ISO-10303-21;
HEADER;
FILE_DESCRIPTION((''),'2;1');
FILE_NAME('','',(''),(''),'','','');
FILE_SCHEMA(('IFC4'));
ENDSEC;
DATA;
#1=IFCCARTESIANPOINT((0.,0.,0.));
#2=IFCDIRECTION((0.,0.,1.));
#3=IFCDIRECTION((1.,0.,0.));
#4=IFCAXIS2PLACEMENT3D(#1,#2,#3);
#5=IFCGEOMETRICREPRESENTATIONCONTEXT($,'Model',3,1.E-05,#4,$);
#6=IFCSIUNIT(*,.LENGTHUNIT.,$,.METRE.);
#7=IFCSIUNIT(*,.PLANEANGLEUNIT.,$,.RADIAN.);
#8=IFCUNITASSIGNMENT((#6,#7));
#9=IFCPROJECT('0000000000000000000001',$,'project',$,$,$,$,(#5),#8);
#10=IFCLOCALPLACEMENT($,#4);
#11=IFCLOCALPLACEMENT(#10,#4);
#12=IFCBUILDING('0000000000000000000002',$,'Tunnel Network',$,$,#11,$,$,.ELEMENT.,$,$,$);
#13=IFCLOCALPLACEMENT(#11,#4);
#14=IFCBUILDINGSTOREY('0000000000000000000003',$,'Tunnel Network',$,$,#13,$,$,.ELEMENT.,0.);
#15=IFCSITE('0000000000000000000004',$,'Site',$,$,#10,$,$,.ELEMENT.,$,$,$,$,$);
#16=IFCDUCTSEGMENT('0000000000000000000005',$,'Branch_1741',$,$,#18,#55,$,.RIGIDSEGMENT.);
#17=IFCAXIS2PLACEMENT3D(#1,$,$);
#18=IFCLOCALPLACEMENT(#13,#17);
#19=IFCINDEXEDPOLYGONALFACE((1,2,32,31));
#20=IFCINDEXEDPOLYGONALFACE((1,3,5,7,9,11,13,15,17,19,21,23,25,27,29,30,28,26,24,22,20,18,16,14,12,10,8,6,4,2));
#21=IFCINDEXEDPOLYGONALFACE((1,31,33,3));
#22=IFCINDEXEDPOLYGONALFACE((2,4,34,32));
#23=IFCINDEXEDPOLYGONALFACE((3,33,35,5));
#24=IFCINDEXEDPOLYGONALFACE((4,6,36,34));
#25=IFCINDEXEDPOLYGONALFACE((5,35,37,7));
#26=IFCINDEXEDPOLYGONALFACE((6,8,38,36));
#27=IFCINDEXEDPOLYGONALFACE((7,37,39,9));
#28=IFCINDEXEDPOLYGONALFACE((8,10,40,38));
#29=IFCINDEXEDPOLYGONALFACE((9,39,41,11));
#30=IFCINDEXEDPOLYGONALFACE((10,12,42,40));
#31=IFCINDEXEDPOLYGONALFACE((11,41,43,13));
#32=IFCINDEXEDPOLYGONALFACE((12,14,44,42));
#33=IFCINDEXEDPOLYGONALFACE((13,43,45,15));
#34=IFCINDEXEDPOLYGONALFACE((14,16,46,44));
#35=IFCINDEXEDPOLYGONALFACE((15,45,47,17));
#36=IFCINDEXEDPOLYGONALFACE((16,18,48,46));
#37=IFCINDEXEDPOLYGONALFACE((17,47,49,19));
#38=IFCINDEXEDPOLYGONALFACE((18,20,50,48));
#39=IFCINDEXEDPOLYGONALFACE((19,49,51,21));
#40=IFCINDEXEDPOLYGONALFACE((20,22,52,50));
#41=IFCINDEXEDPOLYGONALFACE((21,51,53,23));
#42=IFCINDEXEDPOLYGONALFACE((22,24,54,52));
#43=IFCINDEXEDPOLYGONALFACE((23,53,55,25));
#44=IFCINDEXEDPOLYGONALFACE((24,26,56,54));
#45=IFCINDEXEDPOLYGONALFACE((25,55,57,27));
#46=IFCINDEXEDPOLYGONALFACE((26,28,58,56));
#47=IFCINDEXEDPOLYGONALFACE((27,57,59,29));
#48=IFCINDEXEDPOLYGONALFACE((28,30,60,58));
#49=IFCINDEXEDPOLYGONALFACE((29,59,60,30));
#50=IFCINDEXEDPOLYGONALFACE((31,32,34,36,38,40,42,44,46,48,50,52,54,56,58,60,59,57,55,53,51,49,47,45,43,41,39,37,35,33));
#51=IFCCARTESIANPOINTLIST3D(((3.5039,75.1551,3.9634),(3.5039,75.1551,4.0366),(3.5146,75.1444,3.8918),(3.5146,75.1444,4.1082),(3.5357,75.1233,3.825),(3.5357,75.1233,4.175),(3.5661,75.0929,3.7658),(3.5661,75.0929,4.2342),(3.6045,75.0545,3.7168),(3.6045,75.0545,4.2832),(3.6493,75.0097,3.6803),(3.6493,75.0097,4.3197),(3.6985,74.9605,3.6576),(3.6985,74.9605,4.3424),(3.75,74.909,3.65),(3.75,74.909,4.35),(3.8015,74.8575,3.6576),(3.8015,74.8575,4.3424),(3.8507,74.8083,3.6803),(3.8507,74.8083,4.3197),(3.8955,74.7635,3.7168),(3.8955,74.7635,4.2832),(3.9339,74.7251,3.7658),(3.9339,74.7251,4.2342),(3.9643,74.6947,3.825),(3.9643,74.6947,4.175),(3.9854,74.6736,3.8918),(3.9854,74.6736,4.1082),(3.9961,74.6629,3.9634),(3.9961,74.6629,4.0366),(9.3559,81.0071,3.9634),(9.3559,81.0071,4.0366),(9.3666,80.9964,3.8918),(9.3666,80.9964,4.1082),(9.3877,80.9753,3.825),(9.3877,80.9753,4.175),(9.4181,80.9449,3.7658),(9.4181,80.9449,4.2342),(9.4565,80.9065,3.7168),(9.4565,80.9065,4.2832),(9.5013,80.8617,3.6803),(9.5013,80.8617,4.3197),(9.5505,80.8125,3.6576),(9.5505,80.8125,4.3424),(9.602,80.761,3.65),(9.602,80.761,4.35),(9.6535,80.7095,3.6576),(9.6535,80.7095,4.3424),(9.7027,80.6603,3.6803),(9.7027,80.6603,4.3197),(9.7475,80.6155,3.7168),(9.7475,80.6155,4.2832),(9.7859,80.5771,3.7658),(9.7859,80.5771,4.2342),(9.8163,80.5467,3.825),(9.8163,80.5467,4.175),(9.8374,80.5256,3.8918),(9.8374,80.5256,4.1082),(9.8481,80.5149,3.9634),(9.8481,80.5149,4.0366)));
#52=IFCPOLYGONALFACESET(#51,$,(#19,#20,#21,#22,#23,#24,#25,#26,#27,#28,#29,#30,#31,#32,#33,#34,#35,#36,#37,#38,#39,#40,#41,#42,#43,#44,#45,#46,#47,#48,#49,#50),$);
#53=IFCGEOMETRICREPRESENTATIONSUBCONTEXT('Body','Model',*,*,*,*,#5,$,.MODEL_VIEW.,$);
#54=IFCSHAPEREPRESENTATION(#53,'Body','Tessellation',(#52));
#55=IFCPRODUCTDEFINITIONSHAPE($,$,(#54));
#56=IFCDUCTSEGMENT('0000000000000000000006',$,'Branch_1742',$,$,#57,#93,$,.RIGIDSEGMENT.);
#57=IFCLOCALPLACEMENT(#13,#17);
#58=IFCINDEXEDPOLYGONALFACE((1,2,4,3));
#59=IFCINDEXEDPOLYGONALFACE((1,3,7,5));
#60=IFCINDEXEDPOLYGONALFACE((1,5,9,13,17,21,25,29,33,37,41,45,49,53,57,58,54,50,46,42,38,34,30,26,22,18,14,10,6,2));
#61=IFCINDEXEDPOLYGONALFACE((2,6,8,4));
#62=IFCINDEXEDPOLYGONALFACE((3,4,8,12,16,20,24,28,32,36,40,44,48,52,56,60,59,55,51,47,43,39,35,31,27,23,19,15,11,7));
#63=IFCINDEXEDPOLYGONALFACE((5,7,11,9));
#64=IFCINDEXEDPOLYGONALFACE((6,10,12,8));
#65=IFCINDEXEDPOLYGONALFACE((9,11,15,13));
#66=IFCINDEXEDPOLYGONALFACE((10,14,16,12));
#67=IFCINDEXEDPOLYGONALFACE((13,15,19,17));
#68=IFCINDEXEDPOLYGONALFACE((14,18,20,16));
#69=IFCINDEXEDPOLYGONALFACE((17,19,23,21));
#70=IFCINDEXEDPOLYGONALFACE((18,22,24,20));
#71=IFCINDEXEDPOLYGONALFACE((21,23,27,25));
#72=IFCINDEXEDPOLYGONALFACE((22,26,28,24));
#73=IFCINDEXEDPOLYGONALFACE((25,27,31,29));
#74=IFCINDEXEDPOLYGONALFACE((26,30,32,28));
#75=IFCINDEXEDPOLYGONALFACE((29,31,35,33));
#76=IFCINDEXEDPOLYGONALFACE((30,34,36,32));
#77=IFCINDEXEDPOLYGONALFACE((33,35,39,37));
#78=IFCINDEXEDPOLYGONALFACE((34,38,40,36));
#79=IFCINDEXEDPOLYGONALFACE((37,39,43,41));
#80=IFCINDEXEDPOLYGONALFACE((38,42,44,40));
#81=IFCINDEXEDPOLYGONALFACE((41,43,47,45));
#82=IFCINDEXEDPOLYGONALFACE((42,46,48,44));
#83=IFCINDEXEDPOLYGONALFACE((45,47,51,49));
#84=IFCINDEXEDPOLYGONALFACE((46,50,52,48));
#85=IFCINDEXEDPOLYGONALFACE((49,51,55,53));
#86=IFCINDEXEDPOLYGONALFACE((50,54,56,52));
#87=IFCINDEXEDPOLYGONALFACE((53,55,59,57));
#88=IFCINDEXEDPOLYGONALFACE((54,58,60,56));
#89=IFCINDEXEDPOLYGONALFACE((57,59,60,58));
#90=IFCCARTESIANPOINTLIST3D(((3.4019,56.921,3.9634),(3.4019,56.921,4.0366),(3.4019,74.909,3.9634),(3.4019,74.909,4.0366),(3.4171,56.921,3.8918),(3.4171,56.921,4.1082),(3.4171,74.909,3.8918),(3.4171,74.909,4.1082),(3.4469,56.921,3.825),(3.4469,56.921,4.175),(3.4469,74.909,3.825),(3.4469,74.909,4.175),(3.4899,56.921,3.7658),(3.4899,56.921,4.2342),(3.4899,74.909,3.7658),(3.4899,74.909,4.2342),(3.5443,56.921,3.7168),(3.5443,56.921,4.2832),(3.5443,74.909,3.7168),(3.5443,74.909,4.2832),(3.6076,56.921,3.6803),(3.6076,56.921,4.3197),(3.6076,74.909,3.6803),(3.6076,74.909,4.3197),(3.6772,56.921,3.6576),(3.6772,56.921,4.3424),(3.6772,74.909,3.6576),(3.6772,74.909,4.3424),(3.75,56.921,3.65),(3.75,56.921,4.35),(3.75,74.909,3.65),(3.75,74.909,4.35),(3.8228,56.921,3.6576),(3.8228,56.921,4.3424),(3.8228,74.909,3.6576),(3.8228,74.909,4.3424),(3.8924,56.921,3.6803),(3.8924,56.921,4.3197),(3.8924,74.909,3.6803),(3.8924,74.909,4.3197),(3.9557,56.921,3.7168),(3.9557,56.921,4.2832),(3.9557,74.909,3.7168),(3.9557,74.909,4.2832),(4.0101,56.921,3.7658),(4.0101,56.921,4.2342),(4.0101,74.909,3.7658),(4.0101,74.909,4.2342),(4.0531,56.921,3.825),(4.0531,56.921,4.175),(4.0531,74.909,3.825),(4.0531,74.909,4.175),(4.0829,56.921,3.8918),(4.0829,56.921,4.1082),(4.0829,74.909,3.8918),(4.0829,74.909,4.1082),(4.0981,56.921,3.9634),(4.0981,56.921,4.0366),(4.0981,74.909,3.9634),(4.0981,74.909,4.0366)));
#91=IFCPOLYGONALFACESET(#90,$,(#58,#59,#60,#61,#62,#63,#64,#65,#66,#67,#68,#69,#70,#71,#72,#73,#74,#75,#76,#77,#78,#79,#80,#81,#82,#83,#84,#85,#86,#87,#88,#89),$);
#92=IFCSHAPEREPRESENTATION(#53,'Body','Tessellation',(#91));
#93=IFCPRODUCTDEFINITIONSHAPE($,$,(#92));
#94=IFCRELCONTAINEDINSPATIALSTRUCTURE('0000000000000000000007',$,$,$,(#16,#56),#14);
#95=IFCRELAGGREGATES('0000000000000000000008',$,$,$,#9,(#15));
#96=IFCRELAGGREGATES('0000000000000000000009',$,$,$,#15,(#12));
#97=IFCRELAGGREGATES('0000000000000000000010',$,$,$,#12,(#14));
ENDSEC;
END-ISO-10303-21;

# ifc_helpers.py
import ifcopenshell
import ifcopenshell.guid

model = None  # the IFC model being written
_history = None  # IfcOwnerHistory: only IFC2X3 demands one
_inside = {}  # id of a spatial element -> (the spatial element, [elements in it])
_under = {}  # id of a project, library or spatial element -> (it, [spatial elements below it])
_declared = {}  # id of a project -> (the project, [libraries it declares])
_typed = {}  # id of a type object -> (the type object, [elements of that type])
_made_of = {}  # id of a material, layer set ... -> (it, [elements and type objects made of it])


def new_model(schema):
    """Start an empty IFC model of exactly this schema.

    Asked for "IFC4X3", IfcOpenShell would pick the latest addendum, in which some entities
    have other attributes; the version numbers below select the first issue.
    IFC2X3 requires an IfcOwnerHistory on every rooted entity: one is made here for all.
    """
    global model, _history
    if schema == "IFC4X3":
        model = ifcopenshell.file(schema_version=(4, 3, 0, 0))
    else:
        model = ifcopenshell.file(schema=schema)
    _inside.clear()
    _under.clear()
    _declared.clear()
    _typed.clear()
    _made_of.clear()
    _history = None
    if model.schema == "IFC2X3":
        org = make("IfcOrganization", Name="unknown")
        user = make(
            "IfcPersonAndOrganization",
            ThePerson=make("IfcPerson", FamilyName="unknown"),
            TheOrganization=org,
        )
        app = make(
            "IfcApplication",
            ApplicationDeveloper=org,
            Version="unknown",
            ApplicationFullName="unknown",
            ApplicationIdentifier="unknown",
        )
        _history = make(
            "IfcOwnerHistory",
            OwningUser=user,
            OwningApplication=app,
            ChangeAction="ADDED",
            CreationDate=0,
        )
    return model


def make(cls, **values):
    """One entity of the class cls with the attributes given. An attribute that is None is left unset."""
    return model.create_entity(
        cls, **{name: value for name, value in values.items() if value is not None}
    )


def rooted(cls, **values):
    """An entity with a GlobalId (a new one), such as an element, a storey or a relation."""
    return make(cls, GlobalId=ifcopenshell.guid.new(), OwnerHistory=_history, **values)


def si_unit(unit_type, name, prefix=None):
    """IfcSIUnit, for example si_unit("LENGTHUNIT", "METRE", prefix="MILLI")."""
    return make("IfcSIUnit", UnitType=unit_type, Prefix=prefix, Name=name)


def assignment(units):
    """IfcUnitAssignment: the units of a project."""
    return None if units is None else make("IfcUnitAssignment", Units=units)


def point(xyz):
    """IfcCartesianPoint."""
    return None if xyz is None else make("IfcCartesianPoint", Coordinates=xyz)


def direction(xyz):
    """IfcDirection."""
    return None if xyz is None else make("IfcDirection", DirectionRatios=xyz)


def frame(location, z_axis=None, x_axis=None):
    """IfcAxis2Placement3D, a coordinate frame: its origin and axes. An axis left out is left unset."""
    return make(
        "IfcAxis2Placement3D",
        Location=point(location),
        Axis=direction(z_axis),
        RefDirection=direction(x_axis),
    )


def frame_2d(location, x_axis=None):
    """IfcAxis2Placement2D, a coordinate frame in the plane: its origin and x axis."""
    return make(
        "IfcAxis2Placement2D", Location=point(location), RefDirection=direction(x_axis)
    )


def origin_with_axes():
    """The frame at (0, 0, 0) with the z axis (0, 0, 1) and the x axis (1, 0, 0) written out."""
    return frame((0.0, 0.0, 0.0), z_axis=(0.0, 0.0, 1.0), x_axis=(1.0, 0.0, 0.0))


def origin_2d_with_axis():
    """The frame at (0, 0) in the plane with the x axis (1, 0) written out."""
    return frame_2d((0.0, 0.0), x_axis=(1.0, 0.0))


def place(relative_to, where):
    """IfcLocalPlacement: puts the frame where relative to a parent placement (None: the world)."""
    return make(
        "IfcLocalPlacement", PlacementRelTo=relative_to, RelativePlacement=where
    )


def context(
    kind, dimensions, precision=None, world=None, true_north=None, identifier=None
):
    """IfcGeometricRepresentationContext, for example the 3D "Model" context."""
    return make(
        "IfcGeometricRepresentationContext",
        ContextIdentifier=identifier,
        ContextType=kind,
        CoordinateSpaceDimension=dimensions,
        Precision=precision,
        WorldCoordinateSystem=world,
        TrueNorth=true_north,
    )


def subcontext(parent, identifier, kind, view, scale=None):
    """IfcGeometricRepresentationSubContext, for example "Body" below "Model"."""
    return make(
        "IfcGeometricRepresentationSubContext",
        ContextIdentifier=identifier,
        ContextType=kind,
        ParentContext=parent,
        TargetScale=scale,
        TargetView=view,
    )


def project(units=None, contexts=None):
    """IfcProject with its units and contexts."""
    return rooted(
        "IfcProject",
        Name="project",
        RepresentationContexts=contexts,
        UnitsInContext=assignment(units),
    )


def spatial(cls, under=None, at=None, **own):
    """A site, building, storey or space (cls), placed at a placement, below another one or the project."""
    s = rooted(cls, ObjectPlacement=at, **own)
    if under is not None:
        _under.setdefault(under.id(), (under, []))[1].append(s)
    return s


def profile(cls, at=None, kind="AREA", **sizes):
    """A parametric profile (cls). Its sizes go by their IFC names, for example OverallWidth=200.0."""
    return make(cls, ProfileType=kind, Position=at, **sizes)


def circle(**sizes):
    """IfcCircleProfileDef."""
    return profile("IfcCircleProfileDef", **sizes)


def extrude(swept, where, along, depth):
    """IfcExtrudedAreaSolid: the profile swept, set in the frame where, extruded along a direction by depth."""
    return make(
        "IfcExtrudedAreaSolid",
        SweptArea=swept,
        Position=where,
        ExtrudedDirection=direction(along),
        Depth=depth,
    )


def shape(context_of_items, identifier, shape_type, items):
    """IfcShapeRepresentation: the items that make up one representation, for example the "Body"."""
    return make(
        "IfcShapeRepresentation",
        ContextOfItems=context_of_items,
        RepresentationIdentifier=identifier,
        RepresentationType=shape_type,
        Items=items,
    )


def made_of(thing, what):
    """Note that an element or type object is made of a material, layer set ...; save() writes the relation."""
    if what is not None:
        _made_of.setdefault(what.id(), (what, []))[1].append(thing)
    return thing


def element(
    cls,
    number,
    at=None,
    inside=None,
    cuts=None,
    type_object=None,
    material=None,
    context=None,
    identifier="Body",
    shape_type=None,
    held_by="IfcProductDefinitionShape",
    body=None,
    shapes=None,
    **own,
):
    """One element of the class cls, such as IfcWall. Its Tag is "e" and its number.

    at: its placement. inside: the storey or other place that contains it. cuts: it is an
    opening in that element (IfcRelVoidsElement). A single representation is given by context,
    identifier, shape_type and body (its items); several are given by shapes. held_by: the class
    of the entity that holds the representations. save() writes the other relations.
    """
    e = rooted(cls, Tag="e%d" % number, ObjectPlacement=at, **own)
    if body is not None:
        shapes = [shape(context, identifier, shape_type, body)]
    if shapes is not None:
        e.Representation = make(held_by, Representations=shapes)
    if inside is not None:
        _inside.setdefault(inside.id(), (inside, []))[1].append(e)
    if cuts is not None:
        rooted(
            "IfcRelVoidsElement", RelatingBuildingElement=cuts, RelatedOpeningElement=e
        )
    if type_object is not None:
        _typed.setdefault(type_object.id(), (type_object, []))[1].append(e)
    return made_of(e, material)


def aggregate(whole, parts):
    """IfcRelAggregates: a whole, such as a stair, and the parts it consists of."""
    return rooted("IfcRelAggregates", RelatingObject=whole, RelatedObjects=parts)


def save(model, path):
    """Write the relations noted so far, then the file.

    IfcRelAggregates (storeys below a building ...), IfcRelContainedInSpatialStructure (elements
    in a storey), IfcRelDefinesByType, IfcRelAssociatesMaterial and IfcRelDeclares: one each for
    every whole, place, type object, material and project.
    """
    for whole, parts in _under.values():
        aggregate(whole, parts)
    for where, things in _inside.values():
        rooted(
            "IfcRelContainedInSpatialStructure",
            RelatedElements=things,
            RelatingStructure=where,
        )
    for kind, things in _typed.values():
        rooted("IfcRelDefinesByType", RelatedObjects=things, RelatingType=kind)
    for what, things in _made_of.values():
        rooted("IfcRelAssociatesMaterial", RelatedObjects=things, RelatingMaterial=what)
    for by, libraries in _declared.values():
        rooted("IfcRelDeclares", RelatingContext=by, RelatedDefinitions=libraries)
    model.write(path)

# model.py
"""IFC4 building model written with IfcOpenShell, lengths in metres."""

from ifc_helpers import new_model, si_unit, frame, origin_with_axes, origin_2d_with_axis, place, context, subcontext, project, spatial, circle, extrude, element, save


model = new_model("IFC4")

# Units and contexts
model_context = context("Model", 3, precision=1e-05, world=origin_with_axes())
body_context = subcontext(model_context, "Body", "Model", "MODEL_VIEW")
ifc_project = project(units=[si_unit("LENGTHUNIT", "METRE"), si_unit("PLANEANGLEUNIT", "RADIAN")], contexts=[model_context])

# Site, building, storey
site_placement = place(None, origin_with_axes())
site = spatial("IfcSite", under=ifc_project, at=site_placement, Name="Site", CompositionType="ELEMENT")
building_placement = place(site_placement, origin_with_axes())
building = spatial("IfcBuilding", under=site, at=building_placement, Name="Tunnel Network", CompositionType="ELEMENT")
storey_placement = place(building_placement, origin_with_axes())
storey = spatial("IfcBuildingStorey", under=building, at=storey_placement, Name="Tunnel Network", CompositionType="ELEMENT", Elevation=0.0)

# Duct segments
duct_segment_1_placement = place(storey_placement, frame((9.602, 80.761, 4.0), z_axis=(-0.707107, -0.707106, 0.0), x_axis=(0.0, 0.0, 1.0)))
element("IfcDuctSegment", 1, at=duct_segment_1_placement, inside=storey, Name="Branch_1741", PredefinedType="RIGIDSEGMENT", context=body_context, shape_type="SweptSolid", body=[
    extrude(circle(Radius=0.35, at=origin_2d_with_axis()), origin_with_axes(), (0.0, 0.0, 1.0), 8.276),
])
duct_segment_2_placement = place(storey_placement, frame((3.75, 74.909, 4.0), z_axis=(0.0, -1.0, 0.0), x_axis=(0.0, 0.0, 1.0)))
element("IfcDuctSegment", 2, at=duct_segment_2_placement, inside=storey, Name="Branch_1742", PredefinedType="RIGIDSEGMENT", context=body_context, shape_type="SweptSolid", body=[
    extrude(circle(Radius=0.35, at=origin_2d_with_axis()), origin_with_axes(), (0.0, 0.0, 1.0), 17.988),
])

save(model, "model.ifc")
